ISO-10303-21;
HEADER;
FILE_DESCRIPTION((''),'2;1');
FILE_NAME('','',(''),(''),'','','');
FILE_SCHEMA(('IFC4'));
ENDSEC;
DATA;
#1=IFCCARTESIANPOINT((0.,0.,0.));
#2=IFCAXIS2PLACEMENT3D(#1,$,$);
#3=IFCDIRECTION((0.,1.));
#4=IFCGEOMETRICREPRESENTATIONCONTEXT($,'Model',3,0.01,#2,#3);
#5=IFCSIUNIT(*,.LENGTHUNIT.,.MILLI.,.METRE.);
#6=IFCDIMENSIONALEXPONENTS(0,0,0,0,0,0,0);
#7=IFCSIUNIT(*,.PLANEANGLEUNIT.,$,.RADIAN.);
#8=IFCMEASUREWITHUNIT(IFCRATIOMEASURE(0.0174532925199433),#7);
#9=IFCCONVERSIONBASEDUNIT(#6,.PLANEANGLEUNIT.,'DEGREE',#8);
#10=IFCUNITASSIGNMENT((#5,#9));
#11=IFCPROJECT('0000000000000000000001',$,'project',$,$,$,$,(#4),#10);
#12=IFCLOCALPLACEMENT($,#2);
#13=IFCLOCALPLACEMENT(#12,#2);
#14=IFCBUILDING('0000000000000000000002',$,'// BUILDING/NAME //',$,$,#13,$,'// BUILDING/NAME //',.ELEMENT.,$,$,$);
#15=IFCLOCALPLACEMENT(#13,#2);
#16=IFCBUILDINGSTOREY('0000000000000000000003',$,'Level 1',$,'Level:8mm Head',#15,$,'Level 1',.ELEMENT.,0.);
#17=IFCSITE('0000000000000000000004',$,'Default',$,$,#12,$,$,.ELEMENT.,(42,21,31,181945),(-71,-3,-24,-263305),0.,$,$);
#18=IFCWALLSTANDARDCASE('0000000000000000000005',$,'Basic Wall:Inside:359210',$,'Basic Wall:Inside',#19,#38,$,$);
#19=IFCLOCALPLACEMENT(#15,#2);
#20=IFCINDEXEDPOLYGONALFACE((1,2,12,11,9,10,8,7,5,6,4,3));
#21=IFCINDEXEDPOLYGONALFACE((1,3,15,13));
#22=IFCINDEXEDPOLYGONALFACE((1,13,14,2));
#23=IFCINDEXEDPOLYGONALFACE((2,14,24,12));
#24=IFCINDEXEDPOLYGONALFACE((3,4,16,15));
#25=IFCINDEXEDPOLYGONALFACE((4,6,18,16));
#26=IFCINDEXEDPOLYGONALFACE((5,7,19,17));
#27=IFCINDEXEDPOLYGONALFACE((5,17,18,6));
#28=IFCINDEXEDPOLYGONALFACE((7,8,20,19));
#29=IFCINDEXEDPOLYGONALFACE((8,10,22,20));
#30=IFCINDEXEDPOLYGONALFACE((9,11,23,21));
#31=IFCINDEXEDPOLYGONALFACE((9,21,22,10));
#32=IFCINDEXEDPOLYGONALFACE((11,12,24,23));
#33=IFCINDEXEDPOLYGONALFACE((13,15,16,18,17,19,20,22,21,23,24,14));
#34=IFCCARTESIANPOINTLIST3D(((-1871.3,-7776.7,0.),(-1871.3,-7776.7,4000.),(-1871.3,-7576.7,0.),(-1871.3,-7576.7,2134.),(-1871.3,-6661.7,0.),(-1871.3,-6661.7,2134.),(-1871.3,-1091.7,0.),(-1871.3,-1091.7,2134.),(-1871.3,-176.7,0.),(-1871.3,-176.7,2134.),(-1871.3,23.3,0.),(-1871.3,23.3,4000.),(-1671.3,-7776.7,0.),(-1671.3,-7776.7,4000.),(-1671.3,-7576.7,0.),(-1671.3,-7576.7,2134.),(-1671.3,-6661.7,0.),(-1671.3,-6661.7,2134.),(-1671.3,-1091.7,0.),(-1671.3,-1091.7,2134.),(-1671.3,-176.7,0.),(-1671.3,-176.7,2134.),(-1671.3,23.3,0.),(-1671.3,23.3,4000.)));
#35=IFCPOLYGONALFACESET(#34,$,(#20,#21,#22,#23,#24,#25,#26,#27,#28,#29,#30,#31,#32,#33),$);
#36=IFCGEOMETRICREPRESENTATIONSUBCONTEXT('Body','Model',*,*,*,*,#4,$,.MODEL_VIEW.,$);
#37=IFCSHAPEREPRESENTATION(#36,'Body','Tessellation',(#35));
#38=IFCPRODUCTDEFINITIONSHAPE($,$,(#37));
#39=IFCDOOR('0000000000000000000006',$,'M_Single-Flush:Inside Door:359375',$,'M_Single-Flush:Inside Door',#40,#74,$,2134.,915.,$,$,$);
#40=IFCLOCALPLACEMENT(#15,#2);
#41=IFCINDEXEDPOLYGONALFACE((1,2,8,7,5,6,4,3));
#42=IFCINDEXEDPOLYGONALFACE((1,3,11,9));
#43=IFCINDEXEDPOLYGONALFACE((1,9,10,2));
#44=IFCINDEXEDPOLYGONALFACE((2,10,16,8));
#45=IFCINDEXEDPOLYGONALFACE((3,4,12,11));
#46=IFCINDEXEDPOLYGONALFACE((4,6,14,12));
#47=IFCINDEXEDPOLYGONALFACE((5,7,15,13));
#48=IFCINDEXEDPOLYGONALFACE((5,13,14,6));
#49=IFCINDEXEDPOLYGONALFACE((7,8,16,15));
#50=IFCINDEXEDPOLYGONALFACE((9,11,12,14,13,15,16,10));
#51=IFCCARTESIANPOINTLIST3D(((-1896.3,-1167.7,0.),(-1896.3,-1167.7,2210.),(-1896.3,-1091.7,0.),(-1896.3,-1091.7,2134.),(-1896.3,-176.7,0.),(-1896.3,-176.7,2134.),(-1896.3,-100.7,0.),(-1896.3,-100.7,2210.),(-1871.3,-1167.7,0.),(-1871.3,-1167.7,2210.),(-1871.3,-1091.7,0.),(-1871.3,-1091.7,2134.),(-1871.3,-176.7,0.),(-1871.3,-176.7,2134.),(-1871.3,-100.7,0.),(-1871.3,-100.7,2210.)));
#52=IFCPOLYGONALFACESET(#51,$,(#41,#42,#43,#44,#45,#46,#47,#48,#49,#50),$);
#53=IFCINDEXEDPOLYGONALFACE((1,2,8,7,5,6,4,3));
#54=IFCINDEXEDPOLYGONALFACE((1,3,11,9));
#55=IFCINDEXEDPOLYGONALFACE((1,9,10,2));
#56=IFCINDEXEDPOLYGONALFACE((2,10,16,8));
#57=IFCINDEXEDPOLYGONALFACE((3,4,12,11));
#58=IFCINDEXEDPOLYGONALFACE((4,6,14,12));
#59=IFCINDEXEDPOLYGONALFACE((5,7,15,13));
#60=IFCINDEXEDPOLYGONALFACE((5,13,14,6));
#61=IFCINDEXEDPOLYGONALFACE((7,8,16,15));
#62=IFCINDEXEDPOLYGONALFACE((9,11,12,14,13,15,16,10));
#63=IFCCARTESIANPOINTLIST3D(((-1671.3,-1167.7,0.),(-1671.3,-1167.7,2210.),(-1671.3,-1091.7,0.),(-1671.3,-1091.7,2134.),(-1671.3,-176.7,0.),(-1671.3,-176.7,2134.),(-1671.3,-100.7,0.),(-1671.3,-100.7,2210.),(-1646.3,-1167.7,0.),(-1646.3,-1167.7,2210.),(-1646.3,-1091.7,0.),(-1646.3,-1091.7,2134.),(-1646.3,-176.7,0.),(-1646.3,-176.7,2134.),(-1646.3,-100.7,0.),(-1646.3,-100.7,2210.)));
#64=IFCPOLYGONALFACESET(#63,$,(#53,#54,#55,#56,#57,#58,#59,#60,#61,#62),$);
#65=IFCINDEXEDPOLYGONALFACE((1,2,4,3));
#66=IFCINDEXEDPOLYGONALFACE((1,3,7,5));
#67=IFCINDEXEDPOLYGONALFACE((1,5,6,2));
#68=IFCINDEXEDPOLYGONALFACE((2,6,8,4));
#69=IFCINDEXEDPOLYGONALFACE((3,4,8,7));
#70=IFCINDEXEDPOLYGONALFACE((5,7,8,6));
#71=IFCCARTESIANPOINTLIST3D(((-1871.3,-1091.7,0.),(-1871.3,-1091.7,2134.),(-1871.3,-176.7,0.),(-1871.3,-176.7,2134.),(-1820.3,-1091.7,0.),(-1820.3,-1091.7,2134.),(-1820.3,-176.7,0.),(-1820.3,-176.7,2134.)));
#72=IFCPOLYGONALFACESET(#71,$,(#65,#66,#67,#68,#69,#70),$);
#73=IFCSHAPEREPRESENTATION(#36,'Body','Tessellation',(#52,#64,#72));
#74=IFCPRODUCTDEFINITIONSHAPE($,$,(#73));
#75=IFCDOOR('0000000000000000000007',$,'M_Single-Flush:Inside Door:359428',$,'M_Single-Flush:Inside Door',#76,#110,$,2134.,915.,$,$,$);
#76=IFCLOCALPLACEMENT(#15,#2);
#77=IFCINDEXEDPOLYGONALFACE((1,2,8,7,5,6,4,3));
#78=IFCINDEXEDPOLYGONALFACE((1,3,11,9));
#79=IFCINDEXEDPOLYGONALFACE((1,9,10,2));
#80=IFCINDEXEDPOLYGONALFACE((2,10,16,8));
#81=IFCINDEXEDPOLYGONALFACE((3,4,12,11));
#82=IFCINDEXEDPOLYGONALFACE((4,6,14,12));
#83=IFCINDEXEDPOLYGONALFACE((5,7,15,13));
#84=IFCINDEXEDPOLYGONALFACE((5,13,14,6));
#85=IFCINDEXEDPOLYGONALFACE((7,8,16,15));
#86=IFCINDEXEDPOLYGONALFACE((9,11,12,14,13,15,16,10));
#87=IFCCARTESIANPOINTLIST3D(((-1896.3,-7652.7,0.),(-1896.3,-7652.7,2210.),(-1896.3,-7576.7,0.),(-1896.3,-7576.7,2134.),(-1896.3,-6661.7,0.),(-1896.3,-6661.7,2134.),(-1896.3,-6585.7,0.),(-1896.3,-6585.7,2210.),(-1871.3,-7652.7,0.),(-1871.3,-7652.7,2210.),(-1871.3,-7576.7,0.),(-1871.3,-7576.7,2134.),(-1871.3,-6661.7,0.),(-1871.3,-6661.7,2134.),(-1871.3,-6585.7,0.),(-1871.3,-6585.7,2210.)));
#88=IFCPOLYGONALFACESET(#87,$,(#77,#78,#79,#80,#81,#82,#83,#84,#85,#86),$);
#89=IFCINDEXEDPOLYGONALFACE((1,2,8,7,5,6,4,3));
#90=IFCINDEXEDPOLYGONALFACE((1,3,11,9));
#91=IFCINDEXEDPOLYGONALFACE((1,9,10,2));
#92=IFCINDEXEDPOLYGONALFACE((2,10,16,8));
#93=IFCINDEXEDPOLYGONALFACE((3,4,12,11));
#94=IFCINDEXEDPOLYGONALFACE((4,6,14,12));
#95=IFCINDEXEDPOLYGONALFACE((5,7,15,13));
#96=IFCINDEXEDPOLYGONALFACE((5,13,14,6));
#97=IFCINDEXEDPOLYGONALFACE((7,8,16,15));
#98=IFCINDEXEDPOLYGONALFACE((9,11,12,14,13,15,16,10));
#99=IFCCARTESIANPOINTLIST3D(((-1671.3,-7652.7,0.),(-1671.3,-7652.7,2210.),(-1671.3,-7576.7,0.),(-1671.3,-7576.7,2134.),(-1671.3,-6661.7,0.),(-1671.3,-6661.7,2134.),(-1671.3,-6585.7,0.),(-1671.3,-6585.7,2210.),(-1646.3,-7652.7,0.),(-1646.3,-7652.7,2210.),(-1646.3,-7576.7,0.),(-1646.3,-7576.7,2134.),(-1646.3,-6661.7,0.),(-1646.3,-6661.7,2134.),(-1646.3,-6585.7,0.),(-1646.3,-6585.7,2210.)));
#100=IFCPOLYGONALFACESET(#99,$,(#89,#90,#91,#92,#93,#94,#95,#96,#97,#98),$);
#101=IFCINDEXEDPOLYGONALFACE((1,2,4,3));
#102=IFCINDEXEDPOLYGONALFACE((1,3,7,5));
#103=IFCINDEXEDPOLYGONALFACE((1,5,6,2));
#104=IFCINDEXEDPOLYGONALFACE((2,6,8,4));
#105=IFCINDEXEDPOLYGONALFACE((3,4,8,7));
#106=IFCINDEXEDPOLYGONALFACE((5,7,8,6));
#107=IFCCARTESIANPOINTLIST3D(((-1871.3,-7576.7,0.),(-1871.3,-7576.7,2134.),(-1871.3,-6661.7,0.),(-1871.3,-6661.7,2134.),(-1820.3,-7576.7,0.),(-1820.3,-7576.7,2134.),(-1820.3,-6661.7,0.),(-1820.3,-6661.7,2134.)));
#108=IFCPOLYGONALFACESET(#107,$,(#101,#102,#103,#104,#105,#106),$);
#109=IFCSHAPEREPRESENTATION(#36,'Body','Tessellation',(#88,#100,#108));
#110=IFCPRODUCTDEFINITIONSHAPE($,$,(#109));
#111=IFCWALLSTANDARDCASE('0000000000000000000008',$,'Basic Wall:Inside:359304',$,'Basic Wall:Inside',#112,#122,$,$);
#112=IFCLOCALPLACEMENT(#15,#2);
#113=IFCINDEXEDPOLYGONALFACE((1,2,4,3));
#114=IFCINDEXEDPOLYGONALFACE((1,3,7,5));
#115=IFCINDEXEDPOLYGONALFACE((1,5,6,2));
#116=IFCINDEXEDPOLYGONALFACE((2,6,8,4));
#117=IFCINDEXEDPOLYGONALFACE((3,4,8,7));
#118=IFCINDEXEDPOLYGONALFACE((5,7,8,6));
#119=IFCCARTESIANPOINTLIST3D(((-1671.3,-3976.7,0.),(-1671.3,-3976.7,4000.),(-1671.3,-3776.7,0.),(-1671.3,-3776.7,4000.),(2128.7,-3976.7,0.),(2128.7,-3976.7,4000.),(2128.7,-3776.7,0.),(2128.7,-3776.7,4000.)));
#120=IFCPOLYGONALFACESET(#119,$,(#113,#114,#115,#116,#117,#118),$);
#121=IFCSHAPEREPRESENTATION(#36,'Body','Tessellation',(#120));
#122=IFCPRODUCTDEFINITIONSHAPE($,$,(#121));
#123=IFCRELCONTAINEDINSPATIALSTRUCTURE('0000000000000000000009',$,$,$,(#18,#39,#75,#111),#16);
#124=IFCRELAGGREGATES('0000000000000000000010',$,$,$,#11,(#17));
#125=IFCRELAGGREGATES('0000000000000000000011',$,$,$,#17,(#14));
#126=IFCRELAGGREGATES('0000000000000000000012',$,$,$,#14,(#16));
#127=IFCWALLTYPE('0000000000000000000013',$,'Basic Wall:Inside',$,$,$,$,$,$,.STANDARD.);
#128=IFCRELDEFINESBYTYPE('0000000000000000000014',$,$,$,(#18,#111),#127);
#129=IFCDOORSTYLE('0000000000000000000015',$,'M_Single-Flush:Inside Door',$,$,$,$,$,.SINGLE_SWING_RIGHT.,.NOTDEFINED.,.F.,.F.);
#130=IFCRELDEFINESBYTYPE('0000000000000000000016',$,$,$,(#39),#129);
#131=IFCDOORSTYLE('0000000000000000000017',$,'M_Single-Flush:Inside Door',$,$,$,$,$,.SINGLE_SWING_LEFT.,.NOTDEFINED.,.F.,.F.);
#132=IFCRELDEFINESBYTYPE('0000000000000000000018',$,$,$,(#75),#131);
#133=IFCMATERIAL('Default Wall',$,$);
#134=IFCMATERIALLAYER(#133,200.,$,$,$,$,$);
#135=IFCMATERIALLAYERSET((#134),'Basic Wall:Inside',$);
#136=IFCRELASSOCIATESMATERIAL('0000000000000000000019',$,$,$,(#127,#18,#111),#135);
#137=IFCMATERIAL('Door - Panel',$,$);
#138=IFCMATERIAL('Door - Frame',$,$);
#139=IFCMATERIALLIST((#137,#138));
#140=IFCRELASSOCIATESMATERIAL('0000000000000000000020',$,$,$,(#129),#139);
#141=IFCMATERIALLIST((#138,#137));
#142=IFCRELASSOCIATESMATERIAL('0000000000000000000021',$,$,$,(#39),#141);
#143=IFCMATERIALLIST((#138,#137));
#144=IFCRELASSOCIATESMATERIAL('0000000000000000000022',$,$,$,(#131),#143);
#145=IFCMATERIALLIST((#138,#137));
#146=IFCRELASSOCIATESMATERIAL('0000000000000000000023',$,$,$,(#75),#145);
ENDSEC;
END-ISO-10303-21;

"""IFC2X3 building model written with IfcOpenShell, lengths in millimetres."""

from ifc_helpers import new_model, entity, si_unit, converted_unit, direction, frame, frame_2d, origin, place, context, subcontext, project, spatial, polyline, rectangle, outline, extrude, clip, halfspace, source, transform, mapped, material, material_list, layer, layer_set, layer_usage, type_object, type_shapes, element, fill, save


model = new_model("IFC2X3")

# Units and contexts
model_context = context("Model", 3, precision=0.01, world=origin(), true_north=direction((0.0, 1.0)))
body_context = subcontext(model_context, "Body", "Model", "MODEL_VIEW")
ifc_project = project(units=[si_unit("LENGTHUNIT", "METRE", prefix="MILLI"), converted_unit("PLANEANGLEUNIT", "DEGREE", entity("IfcRatioMeasure", 0.0174532925199433), si_unit("PLANEANGLEUNIT", "RADIAN"), dimensions=[0, 0, 0, 0, 0, 0, 0])], contexts=[model_context])

# Site, building, storey
site_placement = place(None, origin())
site = spatial("IfcSite", under=ifc_project, at=site_placement, Name="Default", CompositionType="ELEMENT", RefLatitude=(42, 21, 31, 181945), RefLongitude=(-71, -3, -24, -263305), RefElevation=0.0)
building_placement = place(site_placement, origin())
building = spatial("IfcBuilding", under=site, at=building_placement, Name="// BUILDING/NAME //", LongName="// BUILDING/NAME //", CompositionType="ELEMENT")
storey_placement = place(building_placement, origin())
storey = spatial("IfcBuildingStorey", under=building, at=storey_placement, Name="Level 1", ObjectType="Level:8mm Head", LongName="Level 1", CompositionType="ELEMENT", Elevation=0.0)

# Shared definitions
ifc_material_1 = material(Name="Default Wall")

# Shared definitions
ifc_material_2 = material(Name="Door - Frame")
ifc_material_3 = material(Name="Door - Panel")

# Wall, openings, doors
ifc_layer_1 = layer(ifc_material_1, 200.0)
ifc_layer_set_1 = layer_set([ifc_layer_1], Name="Basic Wall:Inside")
ifc_layer_usage_1 = layer_usage(ifc_layer_set_1, "AXIS2", "NEGATIVE", 100.0)
wall_type_1 = type_object("IfcWallType", Name="Basic Wall:Inside", PredefinedType="STANDARD", material=ifc_layer_set_1)
wall_1_placement = place(storey_placement, frame((-1771.3, 23.3, 0.0), z_axis=(0.0, 0.0, 1.0), x_axis=(0.0, -1.0, 0.0)))
wall_1 = element("IfcWallStandardCase", 1, at=wall_1_placement, inside=storey, type_object=wall_type_1, material=ifc_layer_usage_1, Name="Basic Wall:Inside:359210", ObjectType="Basic Wall:Inside", context=body_context, shape_type="Clipping", body=[
    clip(extrude(rectangle(XDim=7800.0, YDim=200.0, at=frame_2d((3900.0, 0.0), x_axis=(-1.0, 0.0))), origin(), (0.0, 0.0, 1.0), 4000.0), halfspace(origin(), True)),
])
opening_1_placement = place(wall_1_placement, frame((1115.0, 100.0, 0.0)))
opening_1 = element("IfcOpeningElement", 2, at=opening_1_placement, cuts=wall_1, ObjectType="Opening", context=body_context, shape_type="SweptSolid", body=[
    extrude(rectangle(XDim=915.0, YDim=2134.0, at=frame_2d((1067.0, 457.5), x_axis=(0.0, 1.0))), frame((0.0, 0.0, 0.0), z_axis=(0.0, -1.0, 0.0), x_axis=(0.0, 0.0, 1.0)), (0.0, 0.0, 1.0), 200.0),
])
opening_2_placement = place(wall_1_placement, frame((7600.0, 100.0, 0.0)))
opening_2 = element("IfcOpeningElement", 3, at=opening_2_placement, cuts=wall_1, ObjectType="Opening", context=body_context, shape_type="SweptSolid", body=[
    extrude(rectangle(XDim=915.0, YDim=2134.0, at=frame_2d((1067.0, 457.5), x_axis=(0.0, -1.0))), frame((0.0, 0.0, 0.0), z_axis=(0.0, -1.0, 0.0), x_axis=(0.0, 0.0, 1.0)), (0.0, 0.0, 1.0), 200.0),
])
ifc_material_list_1 = material_list([ifc_material_2, ifc_material_3])
ifc_material_list_2 = material_list([ifc_material_3, ifc_material_2])
door_style_1 = type_object("IfcDoorStyle", Name="M_Single-Flush:Inside Door", ConstructionType="NOTDEFINED", OperationType="SINGLE_SWING_RIGHT", ParameterTakesPrecedence=False, Sizeable=False, material=ifc_material_list_2)
shared_shape_1 = source(origin(), body_context, "Body", "SweptSolid", [
    extrude(outline(polyline([(-533.5, -1124.0), (533.5, -1124.0), (533.5, 1086.0), (457.5, 1086.0), (457.5, -1048.0), (-457.5, -1048.0), (-457.5, 1086.0), (-533.5, 1086.0), (-533.5, -1124.0)])), frame((457.5, 200.0, 1086.0), z_axis=(0.0, 1.0, 0.0), x_axis=(1.0, 0.0, 0.0)), (0.0, 0.0, 1.0), 25.0),
    extrude(outline(polyline([(-1124.0, -533.5), (1086.0, -533.5), (1086.0, -457.5), (-1048.0, -457.5), (-1048.0, 457.5), (1086.0, 457.5), (1086.0, 533.5), (-1124.0, 533.5), (-1124.0, -533.5)])), frame((457.5, -25.0, 1086.0), z_axis=(0.0, 1.0, 0.0), x_axis=(0.0, 0.0, -1.0)), (0.0, 0.0, 1.0), 25.0),
    extrude(rectangle(XDim=51.0, YDim=915.0, at=frame_2d((0.0, 0.0), x_axis=(1.0, 0.0))), frame((457.5, 174.5, 0.0), z_axis=(0.0, 0.0, 1.0), x_axis=(0.0, 1.0, 0.0)), (0.0, 0.0, 1.0), 2134.0),
])
type_shapes(door_style_1, [shared_shape_1])
door_1_placement = place(opening_1_placement, frame((0.0, 0.0, 0.0), z_axis=(0.0, 0.0, 1.0), x_axis=(-1.0, 0.0, 0.0)))
door_1 = element("IfcDoor", 4, at=door_1_placement, inside=storey, type_object=door_style_1, material=ifc_material_list_1, Name="M_Single-Flush:Inside Door:359375", ObjectType="M_Single-Flush:Inside Door", OverallHeight=2134.0, OverallWidth=915.0, context=body_context, shape_type="MappedRepresentation", body=[
    mapped(shared_shape_1, transform((0.0, 0.0, 0.0), scale=1.0)),
])
fill(opening_1, door_1)
ifc_material_list_3 = material_list([ifc_material_2, ifc_material_3])
ifc_material_list_4 = material_list([ifc_material_2, ifc_material_3])
door_style_2 = type_object("IfcDoorStyle", Name="M_Single-Flush:Inside Door", ConstructionType="NOTDEFINED", OperationType="SINGLE_SWING_LEFT", ParameterTakesPrecedence=False, Sizeable=False, material=ifc_material_list_4)
shared_shape_2 = source(origin(), body_context, "Body", "SweptSolid", [
    extrude(outline(polyline([(-533.5, -1124.0), (533.5, -1124.0), (533.5, 1086.0), (457.5, 1086.0), (457.5, -1048.0), (-457.5, -1048.0), (-457.5, 1086.0), (-533.5, 1086.0), (-533.5, -1124.0)])), frame((457.5, 225.0, 1086.0), z_axis=(0.0, -1.0, 0.0), x_axis=(-1.0, 0.0, 0.0)), (0.0, 0.0, 1.0), 25.0),
    extrude(outline(polyline([(-1124.0, -533.5), (1086.0, -533.5), (1086.0, -457.5), (-1048.0, -457.5), (-1048.0, 457.5), (1086.0, 457.5), (1086.0, 533.5), (-1124.0, 533.5), (-1124.0, -533.5)])), frame((457.5, 0.0, 1086.0), z_axis=(0.0, -1.0, 0.0), x_axis=(0.0, 0.0, -1.0)), (0.0, 0.0, 1.0), 25.0),
    extrude(rectangle(XDim=915.0, YDim=51.0, at=frame_2d((0.0, 0.0), x_axis=(1.0, 0.0))), frame((457.5, 174.5, 0.0)), (0.0, 0.0, 1.0), 2134.0),
])
type_shapes(door_style_2, [shared_shape_2])
door_2_placement = place(opening_2_placement, frame((0.0, 0.0, 0.0), z_axis=(0.0, 0.0, 1.0), x_axis=(-1.0, 0.0, 0.0)))
door_2 = element("IfcDoor", 5, at=door_2_placement, inside=storey, type_object=door_style_2, material=ifc_material_list_3, Name="M_Single-Flush:Inside Door:359428", ObjectType="M_Single-Flush:Inside Door", OverallHeight=2134.0, OverallWidth=915.0, context=body_context, shape_type="MappedRepresentation", body=[
    mapped(shared_shape_2, transform((0.0, 0.0, 0.0), scale=1.0)),
])
fill(opening_2, door_2)

# Wall
ifc_layer_usage_2 = layer_usage(ifc_layer_set_1, "AXIS2", "NEGATIVE", 100.0)
wall_2_placement = place(storey_placement, frame((-1671.3, -3876.7, 0.0)))
element("IfcWallStandardCase", 6, at=wall_2_placement, inside=storey, type_object=wall_type_1, material=ifc_layer_usage_2, Name="Basic Wall:Inside:359304", ObjectType="Basic Wall:Inside", context=body_context, shape_type="Clipping", body=[
    clip(extrude(rectangle(XDim=3800.0, YDim=200.0, at=frame_2d((1900.0, 0.0), x_axis=(-1.0, 0.0))), origin(), (0.0, 0.0, 1.0), 4000.0), halfspace(origin(), True)),
])

save(model, "model.ifc")
